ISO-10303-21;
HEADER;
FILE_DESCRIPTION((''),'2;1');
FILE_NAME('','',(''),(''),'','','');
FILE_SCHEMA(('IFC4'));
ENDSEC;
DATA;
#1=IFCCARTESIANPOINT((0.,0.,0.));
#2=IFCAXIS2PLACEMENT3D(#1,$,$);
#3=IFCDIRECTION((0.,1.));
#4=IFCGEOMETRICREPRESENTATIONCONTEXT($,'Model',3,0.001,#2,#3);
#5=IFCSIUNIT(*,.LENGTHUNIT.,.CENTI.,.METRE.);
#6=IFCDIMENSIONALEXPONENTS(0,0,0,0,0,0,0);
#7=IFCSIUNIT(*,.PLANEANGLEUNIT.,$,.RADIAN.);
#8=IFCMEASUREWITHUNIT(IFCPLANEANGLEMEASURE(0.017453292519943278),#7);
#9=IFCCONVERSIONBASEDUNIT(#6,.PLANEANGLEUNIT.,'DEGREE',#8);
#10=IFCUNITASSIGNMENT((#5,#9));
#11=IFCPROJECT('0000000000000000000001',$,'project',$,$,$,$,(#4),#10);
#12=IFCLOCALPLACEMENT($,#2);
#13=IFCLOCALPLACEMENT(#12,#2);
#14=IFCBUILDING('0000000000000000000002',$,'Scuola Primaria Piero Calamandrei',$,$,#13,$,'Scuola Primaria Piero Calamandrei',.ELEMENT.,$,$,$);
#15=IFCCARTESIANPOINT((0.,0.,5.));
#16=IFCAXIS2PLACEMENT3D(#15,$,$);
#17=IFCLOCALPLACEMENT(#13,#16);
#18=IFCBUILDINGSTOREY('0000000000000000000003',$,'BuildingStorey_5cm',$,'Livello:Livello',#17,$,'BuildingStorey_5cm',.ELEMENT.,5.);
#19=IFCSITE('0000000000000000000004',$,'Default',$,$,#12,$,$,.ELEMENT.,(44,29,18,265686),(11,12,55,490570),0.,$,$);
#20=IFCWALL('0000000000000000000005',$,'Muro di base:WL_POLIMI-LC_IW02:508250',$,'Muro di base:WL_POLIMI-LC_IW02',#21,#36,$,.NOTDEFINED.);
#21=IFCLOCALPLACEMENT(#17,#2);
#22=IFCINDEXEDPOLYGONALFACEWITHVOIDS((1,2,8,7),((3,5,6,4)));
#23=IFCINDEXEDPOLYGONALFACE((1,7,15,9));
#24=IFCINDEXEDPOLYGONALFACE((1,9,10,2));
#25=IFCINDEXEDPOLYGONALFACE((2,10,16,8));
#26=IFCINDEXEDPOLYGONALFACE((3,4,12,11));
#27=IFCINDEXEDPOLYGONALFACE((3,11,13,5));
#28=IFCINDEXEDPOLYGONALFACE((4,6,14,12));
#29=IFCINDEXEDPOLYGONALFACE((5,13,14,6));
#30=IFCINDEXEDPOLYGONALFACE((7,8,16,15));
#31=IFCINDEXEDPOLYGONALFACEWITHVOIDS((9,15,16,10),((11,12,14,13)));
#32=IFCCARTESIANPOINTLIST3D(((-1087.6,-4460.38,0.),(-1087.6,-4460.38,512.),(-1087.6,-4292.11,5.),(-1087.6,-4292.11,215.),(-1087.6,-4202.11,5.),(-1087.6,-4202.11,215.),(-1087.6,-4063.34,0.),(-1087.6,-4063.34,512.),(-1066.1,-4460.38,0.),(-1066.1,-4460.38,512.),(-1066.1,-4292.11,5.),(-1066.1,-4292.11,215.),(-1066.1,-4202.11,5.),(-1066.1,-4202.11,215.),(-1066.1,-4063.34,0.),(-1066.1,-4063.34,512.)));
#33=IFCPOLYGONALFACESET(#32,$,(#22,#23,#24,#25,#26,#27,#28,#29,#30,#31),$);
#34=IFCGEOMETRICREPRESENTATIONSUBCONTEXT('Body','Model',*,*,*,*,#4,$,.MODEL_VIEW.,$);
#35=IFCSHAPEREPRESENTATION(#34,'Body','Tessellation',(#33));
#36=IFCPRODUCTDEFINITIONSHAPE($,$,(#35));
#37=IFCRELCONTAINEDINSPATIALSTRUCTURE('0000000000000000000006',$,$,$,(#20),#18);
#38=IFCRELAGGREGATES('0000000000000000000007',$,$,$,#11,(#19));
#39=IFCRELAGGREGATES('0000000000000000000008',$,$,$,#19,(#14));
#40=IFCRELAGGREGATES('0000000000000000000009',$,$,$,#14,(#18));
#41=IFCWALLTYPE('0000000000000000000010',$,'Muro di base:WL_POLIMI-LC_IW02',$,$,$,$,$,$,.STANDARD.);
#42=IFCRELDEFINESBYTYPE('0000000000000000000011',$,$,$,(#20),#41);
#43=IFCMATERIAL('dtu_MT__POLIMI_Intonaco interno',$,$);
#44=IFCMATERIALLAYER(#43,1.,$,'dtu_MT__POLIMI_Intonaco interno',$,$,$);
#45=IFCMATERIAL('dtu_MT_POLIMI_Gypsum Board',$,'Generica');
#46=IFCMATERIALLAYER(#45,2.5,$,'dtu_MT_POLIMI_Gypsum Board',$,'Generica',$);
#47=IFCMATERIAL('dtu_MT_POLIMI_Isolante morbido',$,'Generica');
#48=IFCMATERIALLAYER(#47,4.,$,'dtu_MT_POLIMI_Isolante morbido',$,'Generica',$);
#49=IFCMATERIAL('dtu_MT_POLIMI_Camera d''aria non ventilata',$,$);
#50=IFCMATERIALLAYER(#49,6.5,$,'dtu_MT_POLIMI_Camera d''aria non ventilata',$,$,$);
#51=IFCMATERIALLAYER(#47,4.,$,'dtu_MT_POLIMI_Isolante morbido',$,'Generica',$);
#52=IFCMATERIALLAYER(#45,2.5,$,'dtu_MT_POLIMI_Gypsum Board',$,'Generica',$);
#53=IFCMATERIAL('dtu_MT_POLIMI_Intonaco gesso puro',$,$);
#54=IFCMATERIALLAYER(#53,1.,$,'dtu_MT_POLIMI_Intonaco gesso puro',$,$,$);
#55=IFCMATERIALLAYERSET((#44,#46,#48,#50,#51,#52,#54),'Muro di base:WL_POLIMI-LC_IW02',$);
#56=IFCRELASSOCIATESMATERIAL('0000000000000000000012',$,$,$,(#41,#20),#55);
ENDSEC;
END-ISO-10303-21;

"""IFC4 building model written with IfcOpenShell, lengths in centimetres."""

from ifc_helpers import new_model, entity, si_unit, converted_unit, direction, frame, frame_2d, origin, place, context, subcontext, project, spatial, rectangle, extrude, material, layer, layer_set, layer_usage, type_object, element, save


model = new_model("IFC4")

# Units and contexts
model_context = context("Model", 3, precision=0.001, world=origin(), true_north=direction((0.0, 1.0)))
body_context = subcontext(model_context, "Body", "Model", "MODEL_VIEW")
ifc_project = project(units=[si_unit("LENGTHUNIT", "METRE", prefix="CENTI"), converted_unit("PLANEANGLEUNIT", "DEGREE", entity("IfcPlaneAngleMeasure", 0.017453292519943278), si_unit("PLANEANGLEUNIT", "RADIAN"), dimensions=[0, 0, 0, 0, 0, 0, 0])], contexts=[model_context])

# Site, building, storey
site_placement = place(None, origin())
site = spatial("IfcSite", under=ifc_project, at=site_placement, Name="Default", CompositionType="ELEMENT", RefLatitude=(44, 29, 18, 265686), RefLongitude=(11, 12, 55, 490570), RefElevation=0.0)
building_placement = place(site_placement, origin())
building = spatial("IfcBuilding", under=site, at=building_placement, Name="Scuola Primaria Piero Calamandrei", LongName="Scuola Primaria Piero Calamandrei", CompositionType="ELEMENT")
storey_placement = place(building_placement, frame((0.0, 0.0, 5.0)))
storey = spatial("IfcBuildingStorey", under=building, at=storey_placement, Name="BuildingStorey_5cm", ObjectType="Livello:Livello", LongName="BuildingStorey_5cm", CompositionType="ELEMENT", Elevation=5.0)

# Shared definitions
ifc_material_1 = material(Name="dtu_MT_POLIMI_Intonaco gesso puro")

# Shared definitions
ifc_material_2 = material(Name="dtu_MT__POLIMI_Intonaco interno")
ifc_material_3 = material(Name="dtu_MT_POLIMI_Isolante morbido", Category="Generica")
ifc_material_4 = material(Name="dtu_MT_POLIMI_Gypsum Board", Category="Generica")

# Wall, opening
ifc_layer_1 = layer(ifc_material_2, 1.0, Name="dtu_MT__POLIMI_Intonaco interno")
ifc_layer_2 = layer(ifc_material_4, 2.5, Name="dtu_MT_POLIMI_Gypsum Board", Category="Generica")
ifc_layer_3 = layer(ifc_material_3, 4.0, Name="dtu_MT_POLIMI_Isolante morbido", Category="Generica")
ifc_material_5 = material(Name="dtu_MT_POLIMI_Camera d'aria non ventilata")
ifc_layer_4 = layer(ifc_material_5, 6.5, Name="dtu_MT_POLIMI_Camera d'aria non ventilata")
ifc_layer_5 = layer(ifc_material_3, 4.0, Name="dtu_MT_POLIMI_Isolante morbido", Category="Generica")
ifc_layer_6 = layer(ifc_material_4, 2.5, Name="dtu_MT_POLIMI_Gypsum Board", Category="Generica")
ifc_layer_7 = layer(ifc_material_1, 1.0, Name="dtu_MT_POLIMI_Intonaco gesso puro")
ifc_layer_set_1 = layer_set([ifc_layer_1, ifc_layer_2, ifc_layer_3, ifc_layer_4, ifc_layer_5, ifc_layer_6, ifc_layer_7], Name="Muro di base:WL_POLIMI-LC_IW02")
ifc_layer_usage_1 = layer_usage(ifc_layer_set_1, "AXIS2", "NEGATIVE", 10.75)
wall_type_1 = type_object("IfcWallType", Name="Muro di base:WL_POLIMI-LC_IW02", PredefinedType="STANDARD", material=ifc_layer_set_1)
wall_1_placement = place(storey_placement, frame((-1076.85, -4460.38, 0.0), z_axis=(0.0, 0.0, 1.0), x_axis=(0.0, 1.0, 0.0)))
wall_1 = element("IfcWall", 1, at=wall_1_placement, inside=storey, type_object=wall_type_1, material=ifc_layer_usage_1, Name="Muro di base:WL_POLIMI-LC_IW02:508250", ObjectType="Muro di base:WL_POLIMI-LC_IW02", PredefinedType="NOTDEFINED", context=body_context, shape_type="SweptSolid", body=[
    extrude(rectangle(XDim=397.05, YDim=21.5, at=frame_2d((198.52, 0.0), x_axis=(-1.0, 0.0))), origin(), (0.0, 0.0, 1.0), 512.0),
])
opening_placement = place(wall_1_placement, frame((168.27, -10.75, 5.0)))
element("IfcOpeningElement", 2, at=opening_placement, cuts=wall_1, PredefinedType="OPENING", context=body_context, shape_type="SweptSolid", body=[
    extrude(rectangle(XDim=210.0, YDim=90.0, at=frame_2d((105.0, 45.0), x_axis=(1.0, 0.0))), frame((0.0, 0.0, 0.0), z_axis=(0.0, 1.0, 0.0), x_axis=(0.0, 0.0, 1.0)), (0.0, 0.0, 1.0), 21.5),
])

save(model, "model.ifc")
